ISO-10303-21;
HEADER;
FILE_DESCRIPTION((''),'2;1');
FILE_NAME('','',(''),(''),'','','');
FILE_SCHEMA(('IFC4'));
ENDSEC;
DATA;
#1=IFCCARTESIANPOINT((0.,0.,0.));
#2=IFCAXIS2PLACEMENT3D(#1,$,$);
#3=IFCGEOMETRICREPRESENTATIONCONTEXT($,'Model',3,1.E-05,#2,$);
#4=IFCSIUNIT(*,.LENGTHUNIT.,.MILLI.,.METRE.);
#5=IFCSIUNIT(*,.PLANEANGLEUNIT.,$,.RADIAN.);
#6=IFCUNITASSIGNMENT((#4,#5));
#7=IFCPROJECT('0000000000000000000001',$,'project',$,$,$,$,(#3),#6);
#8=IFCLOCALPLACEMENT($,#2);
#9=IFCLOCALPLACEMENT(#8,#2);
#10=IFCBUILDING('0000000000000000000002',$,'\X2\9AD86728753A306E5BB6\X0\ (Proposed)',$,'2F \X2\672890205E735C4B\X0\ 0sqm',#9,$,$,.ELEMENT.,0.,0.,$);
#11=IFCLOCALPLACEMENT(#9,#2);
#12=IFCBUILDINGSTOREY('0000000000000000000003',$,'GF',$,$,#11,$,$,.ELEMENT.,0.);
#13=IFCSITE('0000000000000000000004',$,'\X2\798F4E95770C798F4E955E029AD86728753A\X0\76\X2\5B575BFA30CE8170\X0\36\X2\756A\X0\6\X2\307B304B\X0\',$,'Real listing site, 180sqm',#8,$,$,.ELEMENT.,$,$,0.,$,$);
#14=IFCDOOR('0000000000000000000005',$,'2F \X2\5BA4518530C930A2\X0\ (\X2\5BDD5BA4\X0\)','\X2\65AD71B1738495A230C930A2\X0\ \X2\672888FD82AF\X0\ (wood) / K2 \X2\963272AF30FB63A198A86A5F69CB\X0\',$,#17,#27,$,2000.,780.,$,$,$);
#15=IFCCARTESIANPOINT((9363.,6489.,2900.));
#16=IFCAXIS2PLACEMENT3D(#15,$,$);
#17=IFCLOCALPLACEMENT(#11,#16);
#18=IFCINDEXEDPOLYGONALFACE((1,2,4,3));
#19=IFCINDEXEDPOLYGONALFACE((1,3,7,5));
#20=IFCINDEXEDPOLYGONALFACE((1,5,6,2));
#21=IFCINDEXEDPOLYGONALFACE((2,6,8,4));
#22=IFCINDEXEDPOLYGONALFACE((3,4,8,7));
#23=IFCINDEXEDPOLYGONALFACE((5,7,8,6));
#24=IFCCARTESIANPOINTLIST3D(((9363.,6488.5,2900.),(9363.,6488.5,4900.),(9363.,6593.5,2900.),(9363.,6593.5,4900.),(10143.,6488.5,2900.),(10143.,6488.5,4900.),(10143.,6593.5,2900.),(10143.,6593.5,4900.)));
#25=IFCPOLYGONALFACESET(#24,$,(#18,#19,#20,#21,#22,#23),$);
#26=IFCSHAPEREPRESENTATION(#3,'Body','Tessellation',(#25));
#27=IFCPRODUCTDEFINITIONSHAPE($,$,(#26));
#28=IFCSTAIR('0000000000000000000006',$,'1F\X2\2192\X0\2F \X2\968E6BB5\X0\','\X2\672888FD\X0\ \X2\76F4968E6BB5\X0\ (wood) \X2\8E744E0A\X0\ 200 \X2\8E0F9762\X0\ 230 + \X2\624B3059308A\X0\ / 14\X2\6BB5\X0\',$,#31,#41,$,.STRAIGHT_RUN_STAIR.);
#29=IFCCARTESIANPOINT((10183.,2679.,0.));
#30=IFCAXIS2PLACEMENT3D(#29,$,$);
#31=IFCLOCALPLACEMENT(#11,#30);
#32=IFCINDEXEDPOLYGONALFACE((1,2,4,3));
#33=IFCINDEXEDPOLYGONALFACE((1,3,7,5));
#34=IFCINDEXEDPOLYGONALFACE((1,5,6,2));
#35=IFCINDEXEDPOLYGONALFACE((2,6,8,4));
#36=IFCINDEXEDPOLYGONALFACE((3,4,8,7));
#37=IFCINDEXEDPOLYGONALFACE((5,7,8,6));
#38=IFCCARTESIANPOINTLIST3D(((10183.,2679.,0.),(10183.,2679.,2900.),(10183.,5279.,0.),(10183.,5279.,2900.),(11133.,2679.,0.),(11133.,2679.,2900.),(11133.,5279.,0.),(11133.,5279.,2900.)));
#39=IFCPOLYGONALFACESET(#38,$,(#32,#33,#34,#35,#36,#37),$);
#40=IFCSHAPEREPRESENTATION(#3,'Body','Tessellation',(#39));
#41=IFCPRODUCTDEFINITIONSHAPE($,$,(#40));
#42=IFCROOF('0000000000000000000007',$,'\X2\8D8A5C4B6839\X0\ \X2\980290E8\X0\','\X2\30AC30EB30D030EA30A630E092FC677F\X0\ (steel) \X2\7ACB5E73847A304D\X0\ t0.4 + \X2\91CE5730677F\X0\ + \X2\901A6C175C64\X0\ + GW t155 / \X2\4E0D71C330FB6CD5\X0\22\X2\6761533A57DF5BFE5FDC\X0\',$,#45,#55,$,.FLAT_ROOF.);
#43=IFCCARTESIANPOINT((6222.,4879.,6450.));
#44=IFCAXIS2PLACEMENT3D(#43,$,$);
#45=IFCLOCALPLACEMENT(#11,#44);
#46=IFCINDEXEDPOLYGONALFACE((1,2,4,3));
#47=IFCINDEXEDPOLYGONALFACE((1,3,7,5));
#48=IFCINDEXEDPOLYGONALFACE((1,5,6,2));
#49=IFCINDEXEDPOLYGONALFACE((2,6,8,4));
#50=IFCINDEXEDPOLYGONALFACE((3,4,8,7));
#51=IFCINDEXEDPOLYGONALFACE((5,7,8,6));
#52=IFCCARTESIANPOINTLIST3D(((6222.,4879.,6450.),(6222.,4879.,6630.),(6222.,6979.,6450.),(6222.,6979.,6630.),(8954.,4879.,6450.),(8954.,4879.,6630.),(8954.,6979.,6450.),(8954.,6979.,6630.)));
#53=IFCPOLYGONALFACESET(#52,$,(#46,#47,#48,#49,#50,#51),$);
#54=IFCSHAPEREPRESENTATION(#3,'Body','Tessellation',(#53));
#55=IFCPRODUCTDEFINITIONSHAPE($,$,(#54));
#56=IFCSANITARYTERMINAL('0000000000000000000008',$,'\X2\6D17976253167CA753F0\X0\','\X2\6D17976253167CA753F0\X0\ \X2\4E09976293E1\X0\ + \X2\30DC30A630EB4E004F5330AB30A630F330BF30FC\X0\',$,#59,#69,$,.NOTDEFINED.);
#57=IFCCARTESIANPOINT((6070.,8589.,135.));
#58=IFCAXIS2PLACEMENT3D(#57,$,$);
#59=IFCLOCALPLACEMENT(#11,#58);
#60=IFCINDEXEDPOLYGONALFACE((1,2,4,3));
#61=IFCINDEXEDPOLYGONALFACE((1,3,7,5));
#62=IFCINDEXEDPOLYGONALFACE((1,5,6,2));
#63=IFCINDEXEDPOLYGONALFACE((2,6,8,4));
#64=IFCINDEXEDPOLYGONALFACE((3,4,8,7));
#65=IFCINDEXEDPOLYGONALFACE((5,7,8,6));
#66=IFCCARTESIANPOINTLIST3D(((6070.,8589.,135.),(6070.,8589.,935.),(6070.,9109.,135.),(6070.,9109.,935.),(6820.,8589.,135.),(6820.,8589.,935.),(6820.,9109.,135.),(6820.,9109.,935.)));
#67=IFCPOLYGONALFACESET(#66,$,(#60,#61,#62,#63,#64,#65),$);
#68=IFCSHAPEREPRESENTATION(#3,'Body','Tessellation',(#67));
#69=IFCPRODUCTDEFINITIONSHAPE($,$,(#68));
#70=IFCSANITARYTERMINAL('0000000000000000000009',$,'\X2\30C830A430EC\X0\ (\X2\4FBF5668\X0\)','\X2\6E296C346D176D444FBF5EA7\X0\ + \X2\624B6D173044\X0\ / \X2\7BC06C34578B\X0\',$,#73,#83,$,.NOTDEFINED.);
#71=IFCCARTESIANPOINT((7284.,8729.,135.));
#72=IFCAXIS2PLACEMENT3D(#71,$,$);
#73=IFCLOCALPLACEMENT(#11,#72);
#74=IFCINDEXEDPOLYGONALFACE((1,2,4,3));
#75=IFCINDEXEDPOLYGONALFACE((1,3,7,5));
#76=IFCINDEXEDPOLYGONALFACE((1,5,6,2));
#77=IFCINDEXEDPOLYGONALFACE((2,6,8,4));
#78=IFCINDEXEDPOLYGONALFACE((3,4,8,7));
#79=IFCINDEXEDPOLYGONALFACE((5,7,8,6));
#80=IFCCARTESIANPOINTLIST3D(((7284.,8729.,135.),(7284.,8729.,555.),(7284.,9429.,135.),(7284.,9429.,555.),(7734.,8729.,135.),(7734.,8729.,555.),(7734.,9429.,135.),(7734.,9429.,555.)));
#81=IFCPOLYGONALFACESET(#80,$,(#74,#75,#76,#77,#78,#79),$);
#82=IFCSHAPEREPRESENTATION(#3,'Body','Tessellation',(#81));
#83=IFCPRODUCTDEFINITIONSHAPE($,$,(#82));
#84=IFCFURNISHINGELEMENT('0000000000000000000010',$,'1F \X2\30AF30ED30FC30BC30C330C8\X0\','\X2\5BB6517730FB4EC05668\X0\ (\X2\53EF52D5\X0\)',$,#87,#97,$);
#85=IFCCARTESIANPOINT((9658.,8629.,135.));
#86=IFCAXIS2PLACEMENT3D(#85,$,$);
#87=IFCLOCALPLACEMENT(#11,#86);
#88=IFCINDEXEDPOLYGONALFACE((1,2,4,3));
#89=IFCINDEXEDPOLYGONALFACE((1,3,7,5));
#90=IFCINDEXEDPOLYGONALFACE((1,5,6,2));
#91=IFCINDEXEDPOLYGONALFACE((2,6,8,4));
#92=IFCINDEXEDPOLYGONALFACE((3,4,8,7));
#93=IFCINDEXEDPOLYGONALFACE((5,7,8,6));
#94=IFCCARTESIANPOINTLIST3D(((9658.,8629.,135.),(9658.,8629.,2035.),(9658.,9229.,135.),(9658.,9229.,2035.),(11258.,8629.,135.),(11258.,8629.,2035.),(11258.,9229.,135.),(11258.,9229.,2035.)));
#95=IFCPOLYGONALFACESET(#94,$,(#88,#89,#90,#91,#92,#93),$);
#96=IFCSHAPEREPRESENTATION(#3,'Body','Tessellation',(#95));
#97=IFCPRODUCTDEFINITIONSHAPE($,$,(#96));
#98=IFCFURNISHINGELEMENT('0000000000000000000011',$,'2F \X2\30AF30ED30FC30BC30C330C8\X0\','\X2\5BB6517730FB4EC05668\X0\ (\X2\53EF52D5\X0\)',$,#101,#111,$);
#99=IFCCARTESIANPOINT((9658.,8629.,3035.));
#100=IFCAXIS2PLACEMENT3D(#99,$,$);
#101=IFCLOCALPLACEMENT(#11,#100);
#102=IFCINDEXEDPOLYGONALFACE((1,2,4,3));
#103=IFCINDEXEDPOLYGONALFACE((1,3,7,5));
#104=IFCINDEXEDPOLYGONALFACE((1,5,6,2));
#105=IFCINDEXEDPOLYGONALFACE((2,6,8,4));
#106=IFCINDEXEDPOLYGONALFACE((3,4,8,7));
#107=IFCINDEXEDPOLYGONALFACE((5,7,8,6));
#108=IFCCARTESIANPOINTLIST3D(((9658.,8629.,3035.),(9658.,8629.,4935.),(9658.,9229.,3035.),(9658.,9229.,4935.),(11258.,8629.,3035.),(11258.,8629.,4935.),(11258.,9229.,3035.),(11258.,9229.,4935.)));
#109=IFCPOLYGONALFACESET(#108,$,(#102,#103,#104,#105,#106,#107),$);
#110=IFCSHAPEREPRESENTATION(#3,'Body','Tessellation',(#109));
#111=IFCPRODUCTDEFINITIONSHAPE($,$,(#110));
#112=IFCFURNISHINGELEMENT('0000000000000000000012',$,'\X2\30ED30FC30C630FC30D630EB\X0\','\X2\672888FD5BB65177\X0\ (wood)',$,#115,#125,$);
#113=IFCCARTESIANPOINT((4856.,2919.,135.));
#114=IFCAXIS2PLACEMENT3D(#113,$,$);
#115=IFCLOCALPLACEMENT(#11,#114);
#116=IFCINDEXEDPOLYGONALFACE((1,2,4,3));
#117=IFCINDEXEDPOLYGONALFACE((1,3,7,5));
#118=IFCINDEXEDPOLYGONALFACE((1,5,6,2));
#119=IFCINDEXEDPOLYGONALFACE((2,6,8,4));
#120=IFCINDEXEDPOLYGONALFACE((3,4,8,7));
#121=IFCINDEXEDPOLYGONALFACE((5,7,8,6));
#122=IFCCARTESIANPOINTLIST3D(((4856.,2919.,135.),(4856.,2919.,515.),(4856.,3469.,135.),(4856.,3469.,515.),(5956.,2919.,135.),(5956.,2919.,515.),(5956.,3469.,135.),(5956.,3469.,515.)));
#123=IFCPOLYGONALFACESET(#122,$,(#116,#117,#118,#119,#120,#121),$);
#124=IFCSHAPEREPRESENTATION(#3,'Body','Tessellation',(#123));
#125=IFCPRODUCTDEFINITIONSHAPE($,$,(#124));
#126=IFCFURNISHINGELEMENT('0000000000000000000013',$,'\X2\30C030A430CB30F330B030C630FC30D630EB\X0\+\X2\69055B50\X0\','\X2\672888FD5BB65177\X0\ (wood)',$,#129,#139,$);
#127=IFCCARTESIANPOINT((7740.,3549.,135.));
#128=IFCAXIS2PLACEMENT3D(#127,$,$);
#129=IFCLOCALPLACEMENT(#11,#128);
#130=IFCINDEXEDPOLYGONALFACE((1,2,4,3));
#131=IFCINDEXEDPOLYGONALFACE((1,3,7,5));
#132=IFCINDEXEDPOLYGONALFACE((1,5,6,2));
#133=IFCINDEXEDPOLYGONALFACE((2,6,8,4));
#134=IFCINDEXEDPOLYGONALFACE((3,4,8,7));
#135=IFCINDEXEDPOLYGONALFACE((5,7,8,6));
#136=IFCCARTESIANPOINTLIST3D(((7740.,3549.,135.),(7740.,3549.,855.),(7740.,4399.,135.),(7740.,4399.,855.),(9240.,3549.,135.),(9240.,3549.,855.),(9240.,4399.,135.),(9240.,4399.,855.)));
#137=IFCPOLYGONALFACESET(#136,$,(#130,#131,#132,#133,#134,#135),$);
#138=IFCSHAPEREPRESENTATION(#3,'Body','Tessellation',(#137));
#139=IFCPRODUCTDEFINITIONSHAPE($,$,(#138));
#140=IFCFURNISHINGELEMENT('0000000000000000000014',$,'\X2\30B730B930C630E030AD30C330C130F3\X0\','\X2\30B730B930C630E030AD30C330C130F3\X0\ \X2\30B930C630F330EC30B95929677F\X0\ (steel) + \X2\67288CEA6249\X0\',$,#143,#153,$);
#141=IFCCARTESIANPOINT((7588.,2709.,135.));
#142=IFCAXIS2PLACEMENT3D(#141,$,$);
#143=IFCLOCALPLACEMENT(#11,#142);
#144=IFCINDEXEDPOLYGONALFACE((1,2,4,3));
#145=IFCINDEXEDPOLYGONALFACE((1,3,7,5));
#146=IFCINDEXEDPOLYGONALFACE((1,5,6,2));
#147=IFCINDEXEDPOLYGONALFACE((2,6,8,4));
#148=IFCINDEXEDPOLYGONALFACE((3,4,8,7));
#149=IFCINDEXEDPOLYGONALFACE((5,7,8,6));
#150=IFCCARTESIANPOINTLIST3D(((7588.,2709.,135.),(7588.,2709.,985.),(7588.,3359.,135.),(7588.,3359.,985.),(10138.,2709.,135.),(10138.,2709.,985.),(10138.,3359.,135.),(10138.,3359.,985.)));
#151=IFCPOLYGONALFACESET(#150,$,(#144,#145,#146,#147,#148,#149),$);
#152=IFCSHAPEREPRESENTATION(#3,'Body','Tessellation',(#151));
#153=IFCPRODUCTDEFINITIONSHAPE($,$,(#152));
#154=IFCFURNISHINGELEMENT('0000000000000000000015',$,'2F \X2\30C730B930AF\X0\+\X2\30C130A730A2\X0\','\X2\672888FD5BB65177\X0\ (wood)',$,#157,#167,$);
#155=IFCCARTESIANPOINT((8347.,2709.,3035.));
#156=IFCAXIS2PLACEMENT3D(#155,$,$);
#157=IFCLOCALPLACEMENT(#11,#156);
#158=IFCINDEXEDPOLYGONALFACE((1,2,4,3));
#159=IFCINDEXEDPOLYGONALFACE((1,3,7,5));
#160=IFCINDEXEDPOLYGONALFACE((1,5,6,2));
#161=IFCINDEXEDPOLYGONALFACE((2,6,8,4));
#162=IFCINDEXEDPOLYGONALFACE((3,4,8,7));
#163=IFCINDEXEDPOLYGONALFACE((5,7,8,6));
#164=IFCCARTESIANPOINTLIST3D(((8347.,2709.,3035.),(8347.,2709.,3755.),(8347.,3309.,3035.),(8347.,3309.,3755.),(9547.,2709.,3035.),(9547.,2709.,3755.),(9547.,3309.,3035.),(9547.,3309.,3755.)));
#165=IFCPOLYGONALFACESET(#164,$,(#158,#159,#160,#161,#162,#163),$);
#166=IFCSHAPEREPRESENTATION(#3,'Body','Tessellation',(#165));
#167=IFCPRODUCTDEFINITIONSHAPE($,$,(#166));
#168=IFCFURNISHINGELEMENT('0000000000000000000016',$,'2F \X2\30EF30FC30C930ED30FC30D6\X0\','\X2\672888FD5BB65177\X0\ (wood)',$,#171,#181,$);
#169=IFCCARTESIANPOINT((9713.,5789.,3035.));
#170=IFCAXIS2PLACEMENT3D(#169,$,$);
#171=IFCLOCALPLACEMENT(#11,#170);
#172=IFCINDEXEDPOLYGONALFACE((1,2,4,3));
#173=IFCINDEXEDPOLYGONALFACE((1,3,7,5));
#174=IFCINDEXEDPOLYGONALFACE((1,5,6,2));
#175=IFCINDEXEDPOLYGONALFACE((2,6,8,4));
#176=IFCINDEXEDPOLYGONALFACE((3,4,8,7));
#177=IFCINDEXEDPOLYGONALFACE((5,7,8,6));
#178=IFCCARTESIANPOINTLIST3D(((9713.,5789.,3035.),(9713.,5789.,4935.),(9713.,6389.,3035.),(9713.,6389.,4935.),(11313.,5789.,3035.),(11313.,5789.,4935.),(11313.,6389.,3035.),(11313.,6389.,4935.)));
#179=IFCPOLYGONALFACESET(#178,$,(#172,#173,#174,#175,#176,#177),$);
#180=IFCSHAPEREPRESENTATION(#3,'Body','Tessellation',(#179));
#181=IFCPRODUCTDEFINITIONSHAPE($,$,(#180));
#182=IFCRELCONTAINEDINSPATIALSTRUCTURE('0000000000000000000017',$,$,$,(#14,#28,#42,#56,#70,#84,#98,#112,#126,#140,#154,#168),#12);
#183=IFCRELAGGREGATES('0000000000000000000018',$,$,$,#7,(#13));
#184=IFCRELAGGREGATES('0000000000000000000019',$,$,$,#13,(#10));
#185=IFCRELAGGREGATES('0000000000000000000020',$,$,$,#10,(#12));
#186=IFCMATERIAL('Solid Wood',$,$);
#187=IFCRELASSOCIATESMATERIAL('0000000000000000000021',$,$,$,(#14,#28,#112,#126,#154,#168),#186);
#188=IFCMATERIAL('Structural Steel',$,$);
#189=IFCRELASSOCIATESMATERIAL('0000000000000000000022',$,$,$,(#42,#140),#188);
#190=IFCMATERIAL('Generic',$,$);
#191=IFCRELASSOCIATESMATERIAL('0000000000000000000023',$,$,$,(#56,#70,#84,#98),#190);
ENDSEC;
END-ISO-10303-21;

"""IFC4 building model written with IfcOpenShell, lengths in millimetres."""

from ifc_helpers import new_model, si_unit, frame, frame_2d, origin, place, context, project, spatial, rectangle, extrude, material, element, save


model = new_model("IFC4")

# Units and contexts
model_context = context("Model", 3, precision=1e-05, world=origin())
ifc_project = project(units=[si_unit("LENGTHUNIT", "METRE", prefix="MILLI"), si_unit("PLANEANGLEUNIT", "RADIAN")], contexts=[model_context])

# Site, building, storey
site_placement = place(None, origin())
site = spatial("IfcSite", under=ifc_project, at=site_placement, Name="福井県福井市高木町76字寺ノ腰36番6ほか", ObjectType="Real listing site, 180sqm", CompositionType="ELEMENT", RefElevation=0.0)
building_placement = place(site_placement, origin())
building = spatial("IfcBuilding", under=site, at=building_placement, Name="高木町の家 (Proposed)", ObjectType="2F 木造平屋 0sqm", CompositionType="ELEMENT", ElevationOfRefHeight=0.0, ElevationOfTerrain=0.0)
storey_placement = place(building_placement, origin())
storey = spatial("IfcBuildingStorey", under=building, at=storey_placement, Name="GF", CompositionType="ELEMENT", Elevation=0.0)

# Shared definitions
ifc_material_1 = material(Name="Solid Wood")

# Door
door_1_placement = place(storey_placement, frame((9363.0, 6489.0, 2900.0)))
element("IfcDoor", 1, at=door_1_placement, inside=storey, material=ifc_material_1, Name="2F 室内ドア (寝室)", Description="断熱玄関ドア 木製芯 (wood) / K2 防犯・採風機構", OverallHeight=2000.0, OverallWidth=780.0, context=model_context, shape_type="SweptSolid", body=[
    extrude(rectangle(XDim=780.0, YDim=105.0, at=frame_2d((390.0, 52.0))), frame((9363.0, 6489.0, 2900.0)), (0.0, 0.0, 1.0), 2000.0),
])

# Stair
stair_placement = place(storey_placement, frame((10183.0, 2679.0, 0.0)))
element("IfcStair", 2, at=stair_placement, inside=storey, material=ifc_material_1, Name="1F→2F 階段", Description="木製 直階段 (wood) 蹴上 200 踏面 230 + 手すり / 14段", PredefinedType="STRAIGHT_RUN_STAIR", context=model_context, shape_type="SweptSolid", body=[
    extrude(rectangle(XDim=950.0, YDim=2600.0, at=frame_2d((475.0, 1300.0))), frame((10183.0, 2679.0, 0.0)), (0.0, 0.0, 1.0), 2900.0),
])

# Roof
ifc_material_2 = material(Name="Structural Steel")
roof_placement = place(storey_placement, frame((6222.0, 4879.0, 6450.0)))
element("IfcRoof", 3, at=roof_placement, inside=storey, material=ifc_material_2, Name="越屋根 頂部", Description="ガルバリウム鋼板 (steel) 立平葺き t0.4 + 野地板 + 通気層 + GW t155 / 不燃・法22条区域対応", PredefinedType="FLAT_ROOF", context=model_context, shape_type="SweptSolid", body=[
    extrude(rectangle(XDim=2732.0, YDim=2100.0, at=frame_2d((1366.0, 1050.0))), frame((6222.0, 4879.0, 6450.0)), (0.0, 0.0, 1.0), 180.0),
])

# Sanitary terminals
ifc_material_3 = material(Name="Generic")
sanitary_terminal_1_placement = place(storey_placement, frame((6070.0, 8589.0, 135.0)))
element("IfcSanitaryTerminal", 4, at=sanitary_terminal_1_placement, inside=storey, material=ifc_material_3, Name="洗面化粧台", Description="洗面化粧台 三面鏡 + ボウル一体カウンター", PredefinedType="NOTDEFINED", context=model_context, shape_type="SweptSolid", body=[
    extrude(rectangle(XDim=750.0, YDim=520.0, at=frame_2d((375.0, 260.0))), frame((6070.0, 8589.0, 135.0)), (0.0, 0.0, 1.0), 800.0),
])
sanitary_terminal_2_placement = place(storey_placement, frame((7284.0, 8729.0, 135.0)))
element("IfcSanitaryTerminal", 5, at=sanitary_terminal_2_placement, inside=storey, material=ifc_material_3, Name="トイレ (便器)", Description="温水洗浄便座 + 手洗い / 節水型", PredefinedType="NOTDEFINED", context=model_context, shape_type="SweptSolid", body=[
    extrude(rectangle(XDim=450.0, YDim=700.0, at=frame_2d((225.0, 350.0))), frame((7284.0, 8729.0, 135.0)), (0.0, 0.0, 1.0), 420.0),
])

# Furnishing elements
furnishing_1_placement = place(storey_placement, frame((9658.0, 8629.0, 135.0)))
element("IfcFurnishingElement", 6, at=furnishing_1_placement, inside=storey, material=ifc_material_3, Name="1F クローゼット", Description="家具・什器 (可動)", context=model_context, shape_type="SweptSolid", body=[
    extrude(rectangle(XDim=1600.0, YDim=600.0, at=frame_2d((800.0, 300.0))), frame((9658.0, 8629.0, 135.0)), (0.0, 0.0, 1.0), 1900.0),
])
furnishing_2_placement = place(storey_placement, frame((9658.0, 8629.0, 3035.0)))
element("IfcFurnishingElement", 7, at=furnishing_2_placement, inside=storey, material=ifc_material_3, Name="2F クローゼット", Description="家具・什器 (可動)", context=model_context, shape_type="SweptSolid", body=[
    extrude(rectangle(XDim=1600.0, YDim=600.0, at=frame_2d((800.0, 300.0))), frame((9658.0, 8629.0, 3035.0)), (0.0, 0.0, 1.0), 1900.0),
])
furnishing_3_placement = place(storey_placement, frame((4856.0, 2919.0, 135.0)))
element("IfcFurnishingElement", 8, at=furnishing_3_placement, inside=storey, material=ifc_material_1, Name="ローテーブル", Description="木製家具 (wood)", context=model_context, shape_type="SweptSolid", body=[
    extrude(rectangle(XDim=1100.0, YDim=550.0, at=frame_2d((550.0, 275.0))), frame((4856.0, 2919.0, 135.0)), (0.0, 0.0, 1.0), 380.0),
])
furnishing_4_placement = place(storey_placement, frame((7740.0, 3549.0, 135.0)))
element("IfcFurnishingElement", 9, at=furnishing_4_placement, inside=storey, material=ifc_material_1, Name="ダイニングテーブル+椅子", Description="木製家具 (wood)", context=model_context, shape_type="SweptSolid", body=[
    extrude(rectangle(XDim=1500.0, YDim=850.0, at=frame_2d((750.0, 425.0))), frame((7740.0, 3549.0, 135.0)), (0.0, 0.0, 1.0), 720.0),
])
furnishing_5_placement = place(storey_placement, frame((7588.0, 2709.0, 135.0)))
element("IfcFurnishingElement", 10, at=furnishing_5_placement, inside=storey, material=ifc_material_2, Name="システムキッチン", Description="システムキッチン ステンレス天板 (steel) + 木質扉", context=model_context, shape_type="SweptSolid", body=[
    extrude(rectangle(XDim=2550.0, YDim=650.0, at=frame_2d((1275.0, 325.0))), frame((7588.0, 2709.0, 135.0)), (0.0, 0.0, 1.0), 850.0),
])
furnishing_6_placement = place(storey_placement, frame((8347.0, 2709.0, 3035.0)))
element("IfcFurnishingElement", 11, at=furnishing_6_placement, inside=storey, material=ifc_material_1, Name="2F デスク+チェア", Description="木製家具 (wood)", context=model_context, shape_type="SweptSolid", body=[
    extrude(rectangle(XDim=1200.0, YDim=600.0, at=frame_2d((600.0, 300.0))), frame((8347.0, 2709.0, 3035.0)), (0.0, 0.0, 1.0), 720.0),
])
furnishing_7_placement = place(storey_placement, frame((9713.0, 5789.0, 3035.0)))
element("IfcFurnishingElement", 12, at=furnishing_7_placement, inside=storey, material=ifc_material_1, Name="2F ワードローブ", Description="木製家具 (wood)", context=model_context, shape_type="SweptSolid", body=[
    extrude(rectangle(XDim=1600.0, YDim=600.0, at=frame_2d((800.0, 300.0))), frame((9713.0, 5789.0, 3035.0)), (0.0, 0.0, 1.0), 1900.0),
])

save(model, "model.ifc")
